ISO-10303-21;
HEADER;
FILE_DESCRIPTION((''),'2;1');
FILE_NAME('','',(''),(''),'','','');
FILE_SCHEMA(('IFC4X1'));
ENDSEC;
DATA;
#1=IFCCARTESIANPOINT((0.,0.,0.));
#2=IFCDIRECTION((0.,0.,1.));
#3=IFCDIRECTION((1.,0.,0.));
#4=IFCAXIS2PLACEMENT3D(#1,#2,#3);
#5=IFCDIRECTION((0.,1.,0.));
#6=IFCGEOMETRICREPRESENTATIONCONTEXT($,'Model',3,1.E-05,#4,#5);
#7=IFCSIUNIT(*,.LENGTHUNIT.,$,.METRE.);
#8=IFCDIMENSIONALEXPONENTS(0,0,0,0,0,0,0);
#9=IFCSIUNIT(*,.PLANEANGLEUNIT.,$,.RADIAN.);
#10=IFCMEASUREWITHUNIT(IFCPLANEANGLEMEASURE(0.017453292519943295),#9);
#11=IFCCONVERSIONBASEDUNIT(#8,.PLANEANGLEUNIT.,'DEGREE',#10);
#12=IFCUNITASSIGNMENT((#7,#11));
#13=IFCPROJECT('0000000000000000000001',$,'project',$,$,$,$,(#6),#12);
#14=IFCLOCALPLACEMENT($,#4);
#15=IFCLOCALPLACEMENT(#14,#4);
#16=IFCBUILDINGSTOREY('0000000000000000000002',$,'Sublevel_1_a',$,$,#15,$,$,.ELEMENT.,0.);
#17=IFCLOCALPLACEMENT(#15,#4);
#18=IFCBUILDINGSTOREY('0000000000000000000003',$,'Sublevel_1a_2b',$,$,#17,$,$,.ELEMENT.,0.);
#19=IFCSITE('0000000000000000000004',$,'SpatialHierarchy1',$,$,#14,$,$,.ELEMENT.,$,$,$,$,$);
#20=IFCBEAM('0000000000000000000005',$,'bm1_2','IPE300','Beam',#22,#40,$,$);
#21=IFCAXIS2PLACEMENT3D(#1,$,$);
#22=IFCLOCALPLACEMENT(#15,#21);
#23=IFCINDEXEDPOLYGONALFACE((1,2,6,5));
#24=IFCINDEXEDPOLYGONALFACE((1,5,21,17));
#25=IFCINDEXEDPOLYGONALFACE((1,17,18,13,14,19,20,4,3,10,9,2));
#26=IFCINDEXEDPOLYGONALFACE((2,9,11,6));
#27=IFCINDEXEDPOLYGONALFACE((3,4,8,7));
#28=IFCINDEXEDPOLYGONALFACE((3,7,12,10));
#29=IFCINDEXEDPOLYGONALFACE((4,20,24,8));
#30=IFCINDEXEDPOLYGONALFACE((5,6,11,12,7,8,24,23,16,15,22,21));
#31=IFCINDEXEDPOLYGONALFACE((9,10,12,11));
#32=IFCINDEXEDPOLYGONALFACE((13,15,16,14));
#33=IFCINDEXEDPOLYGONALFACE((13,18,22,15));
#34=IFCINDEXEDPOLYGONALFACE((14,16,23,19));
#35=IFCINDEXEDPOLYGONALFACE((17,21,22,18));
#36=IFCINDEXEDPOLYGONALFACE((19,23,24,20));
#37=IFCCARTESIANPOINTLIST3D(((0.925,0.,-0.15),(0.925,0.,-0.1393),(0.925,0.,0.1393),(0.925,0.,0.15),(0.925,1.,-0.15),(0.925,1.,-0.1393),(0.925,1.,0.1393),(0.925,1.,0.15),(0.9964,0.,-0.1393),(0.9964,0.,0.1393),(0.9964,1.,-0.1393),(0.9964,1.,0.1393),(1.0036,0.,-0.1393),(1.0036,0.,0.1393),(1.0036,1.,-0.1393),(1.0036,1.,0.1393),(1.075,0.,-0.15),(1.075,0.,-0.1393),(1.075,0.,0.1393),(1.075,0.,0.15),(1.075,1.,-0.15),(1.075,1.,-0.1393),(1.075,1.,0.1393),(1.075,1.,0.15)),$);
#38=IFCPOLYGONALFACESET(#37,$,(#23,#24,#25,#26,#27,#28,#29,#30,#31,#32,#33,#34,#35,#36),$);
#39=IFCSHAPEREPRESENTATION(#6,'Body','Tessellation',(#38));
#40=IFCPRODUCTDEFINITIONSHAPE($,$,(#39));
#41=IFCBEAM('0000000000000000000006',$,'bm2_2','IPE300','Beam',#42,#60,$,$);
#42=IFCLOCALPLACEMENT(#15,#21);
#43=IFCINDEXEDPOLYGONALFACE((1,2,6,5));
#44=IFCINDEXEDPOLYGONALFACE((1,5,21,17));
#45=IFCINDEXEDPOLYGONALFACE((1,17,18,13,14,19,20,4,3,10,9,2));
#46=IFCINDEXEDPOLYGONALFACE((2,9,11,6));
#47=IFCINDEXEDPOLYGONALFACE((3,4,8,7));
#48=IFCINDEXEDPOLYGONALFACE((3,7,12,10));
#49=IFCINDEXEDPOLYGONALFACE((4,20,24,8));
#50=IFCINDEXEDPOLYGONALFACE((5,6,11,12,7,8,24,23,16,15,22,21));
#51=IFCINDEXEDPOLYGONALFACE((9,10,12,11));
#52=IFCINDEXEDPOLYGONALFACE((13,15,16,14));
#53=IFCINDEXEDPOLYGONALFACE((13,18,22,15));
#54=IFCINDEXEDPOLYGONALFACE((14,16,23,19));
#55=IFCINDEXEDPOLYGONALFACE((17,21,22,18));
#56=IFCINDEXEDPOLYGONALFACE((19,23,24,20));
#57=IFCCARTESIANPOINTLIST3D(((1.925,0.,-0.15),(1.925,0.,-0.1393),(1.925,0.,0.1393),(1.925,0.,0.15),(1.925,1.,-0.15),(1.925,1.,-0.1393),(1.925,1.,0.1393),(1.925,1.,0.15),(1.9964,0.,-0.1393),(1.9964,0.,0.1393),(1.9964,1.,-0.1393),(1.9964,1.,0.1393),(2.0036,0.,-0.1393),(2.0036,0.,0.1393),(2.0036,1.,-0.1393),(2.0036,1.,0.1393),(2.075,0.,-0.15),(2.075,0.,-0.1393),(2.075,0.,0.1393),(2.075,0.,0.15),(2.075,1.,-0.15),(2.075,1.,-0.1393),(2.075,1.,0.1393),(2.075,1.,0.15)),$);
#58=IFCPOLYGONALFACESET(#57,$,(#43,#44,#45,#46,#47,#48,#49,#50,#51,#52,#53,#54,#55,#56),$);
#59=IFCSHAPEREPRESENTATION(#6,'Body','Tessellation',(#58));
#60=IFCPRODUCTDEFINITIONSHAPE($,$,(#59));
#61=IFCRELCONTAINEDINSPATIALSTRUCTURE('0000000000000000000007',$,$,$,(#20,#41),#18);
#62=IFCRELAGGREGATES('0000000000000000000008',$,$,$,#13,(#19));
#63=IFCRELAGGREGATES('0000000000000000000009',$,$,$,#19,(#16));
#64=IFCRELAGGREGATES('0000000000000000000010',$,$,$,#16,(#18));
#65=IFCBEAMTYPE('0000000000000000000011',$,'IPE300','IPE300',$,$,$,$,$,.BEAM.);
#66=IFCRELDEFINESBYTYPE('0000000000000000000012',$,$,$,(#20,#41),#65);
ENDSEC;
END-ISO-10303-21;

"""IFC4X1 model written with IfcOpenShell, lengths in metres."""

from ifc_helpers import new_model, entity, si_unit, converted_unit, direction, frame, origin, origin_with_axes, place, context, project, spatial, i_section, extrude, type_object, element, save


model = new_model("IFC4X1")

# Units and contexts
model_context = context("Model", 3, precision=1e-05, world=origin_with_axes(), true_north=direction((0.0, 1.0, 0.0)))
ifc_project = project(units=[si_unit("LENGTHUNIT", "METRE"), converted_unit("PLANEANGLEUNIT", "DEGREE", entity("IfcPlaneAngleMeasure", 0.017453292519943295), si_unit("PLANEANGLEUNIT", "RADIAN"), dimensions=[0, 0, 0, 0, 0, 0, 0])], contexts=[model_context])

# Site, storeys
site_placement = place(None, origin_with_axes())
site = spatial("IfcSite", under=ifc_project, at=site_placement, Name="SpatialHierarchy1", CompositionType="ELEMENT")
storey_1_placement = place(site_placement, origin_with_axes())
storey_1 = spatial("IfcBuildingStorey", under=site, at=storey_1_placement, Name="Sublevel_1_a", CompositionType="ELEMENT", Elevation=0.0)
storey_2_placement = place(storey_1_placement, origin_with_axes())
storey_2 = spatial("IfcBuildingStorey", under=storey_1, at=storey_2_placement, Name="Sublevel_1a_2b", CompositionType="ELEMENT", Elevation=0.0)

# Beams
beam_type = type_object("IfcBeamType", Name="IPE300", Description="IPE300", PredefinedType="BEAM")
placement_1 = place(storey_2_placement, origin_with_axes())
beam_1_placement = place(placement_1, frame((1.0, 0.0, 0.0), z_axis=(0.0, 1.0, 0.0), x_axis=(-1.0, 0.0, 0.0)))
element("IfcBeam", 1, at=beam_1_placement, inside=storey_2, type_object=beam_type, Name="bm1_2", Description="IPE300", ObjectType="Beam", context=model_context, shape_type="SweptSolid", body=[
    extrude(i_section(OverallWidth=0.15, OverallDepth=0.3, WebThickness=0.0071, FlangeThickness=0.0107), origin(), (0.0, 0.0, 1.0), 1.0),
])
placement_2 = place(storey_2_placement, origin_with_axes())
beam_2_placement = place(placement_2, frame((2.0, 0.0, 0.0), z_axis=(0.0, 1.0, 0.0), x_axis=(-1.0, 0.0, 0.0)))
element("IfcBeam", 2, at=beam_2_placement, inside=storey_2, type_object=beam_type, Name="bm2_2", Description="IPE300", ObjectType="Beam", context=model_context, shape_type="SweptSolid", body=[
    extrude(i_section(OverallWidth=0.15, OverallDepth=0.3, WebThickness=0.0071, FlangeThickness=0.0107), origin(), (0.0, 0.0, 1.0), 1.0),
])

save(model, "model.ifc")
